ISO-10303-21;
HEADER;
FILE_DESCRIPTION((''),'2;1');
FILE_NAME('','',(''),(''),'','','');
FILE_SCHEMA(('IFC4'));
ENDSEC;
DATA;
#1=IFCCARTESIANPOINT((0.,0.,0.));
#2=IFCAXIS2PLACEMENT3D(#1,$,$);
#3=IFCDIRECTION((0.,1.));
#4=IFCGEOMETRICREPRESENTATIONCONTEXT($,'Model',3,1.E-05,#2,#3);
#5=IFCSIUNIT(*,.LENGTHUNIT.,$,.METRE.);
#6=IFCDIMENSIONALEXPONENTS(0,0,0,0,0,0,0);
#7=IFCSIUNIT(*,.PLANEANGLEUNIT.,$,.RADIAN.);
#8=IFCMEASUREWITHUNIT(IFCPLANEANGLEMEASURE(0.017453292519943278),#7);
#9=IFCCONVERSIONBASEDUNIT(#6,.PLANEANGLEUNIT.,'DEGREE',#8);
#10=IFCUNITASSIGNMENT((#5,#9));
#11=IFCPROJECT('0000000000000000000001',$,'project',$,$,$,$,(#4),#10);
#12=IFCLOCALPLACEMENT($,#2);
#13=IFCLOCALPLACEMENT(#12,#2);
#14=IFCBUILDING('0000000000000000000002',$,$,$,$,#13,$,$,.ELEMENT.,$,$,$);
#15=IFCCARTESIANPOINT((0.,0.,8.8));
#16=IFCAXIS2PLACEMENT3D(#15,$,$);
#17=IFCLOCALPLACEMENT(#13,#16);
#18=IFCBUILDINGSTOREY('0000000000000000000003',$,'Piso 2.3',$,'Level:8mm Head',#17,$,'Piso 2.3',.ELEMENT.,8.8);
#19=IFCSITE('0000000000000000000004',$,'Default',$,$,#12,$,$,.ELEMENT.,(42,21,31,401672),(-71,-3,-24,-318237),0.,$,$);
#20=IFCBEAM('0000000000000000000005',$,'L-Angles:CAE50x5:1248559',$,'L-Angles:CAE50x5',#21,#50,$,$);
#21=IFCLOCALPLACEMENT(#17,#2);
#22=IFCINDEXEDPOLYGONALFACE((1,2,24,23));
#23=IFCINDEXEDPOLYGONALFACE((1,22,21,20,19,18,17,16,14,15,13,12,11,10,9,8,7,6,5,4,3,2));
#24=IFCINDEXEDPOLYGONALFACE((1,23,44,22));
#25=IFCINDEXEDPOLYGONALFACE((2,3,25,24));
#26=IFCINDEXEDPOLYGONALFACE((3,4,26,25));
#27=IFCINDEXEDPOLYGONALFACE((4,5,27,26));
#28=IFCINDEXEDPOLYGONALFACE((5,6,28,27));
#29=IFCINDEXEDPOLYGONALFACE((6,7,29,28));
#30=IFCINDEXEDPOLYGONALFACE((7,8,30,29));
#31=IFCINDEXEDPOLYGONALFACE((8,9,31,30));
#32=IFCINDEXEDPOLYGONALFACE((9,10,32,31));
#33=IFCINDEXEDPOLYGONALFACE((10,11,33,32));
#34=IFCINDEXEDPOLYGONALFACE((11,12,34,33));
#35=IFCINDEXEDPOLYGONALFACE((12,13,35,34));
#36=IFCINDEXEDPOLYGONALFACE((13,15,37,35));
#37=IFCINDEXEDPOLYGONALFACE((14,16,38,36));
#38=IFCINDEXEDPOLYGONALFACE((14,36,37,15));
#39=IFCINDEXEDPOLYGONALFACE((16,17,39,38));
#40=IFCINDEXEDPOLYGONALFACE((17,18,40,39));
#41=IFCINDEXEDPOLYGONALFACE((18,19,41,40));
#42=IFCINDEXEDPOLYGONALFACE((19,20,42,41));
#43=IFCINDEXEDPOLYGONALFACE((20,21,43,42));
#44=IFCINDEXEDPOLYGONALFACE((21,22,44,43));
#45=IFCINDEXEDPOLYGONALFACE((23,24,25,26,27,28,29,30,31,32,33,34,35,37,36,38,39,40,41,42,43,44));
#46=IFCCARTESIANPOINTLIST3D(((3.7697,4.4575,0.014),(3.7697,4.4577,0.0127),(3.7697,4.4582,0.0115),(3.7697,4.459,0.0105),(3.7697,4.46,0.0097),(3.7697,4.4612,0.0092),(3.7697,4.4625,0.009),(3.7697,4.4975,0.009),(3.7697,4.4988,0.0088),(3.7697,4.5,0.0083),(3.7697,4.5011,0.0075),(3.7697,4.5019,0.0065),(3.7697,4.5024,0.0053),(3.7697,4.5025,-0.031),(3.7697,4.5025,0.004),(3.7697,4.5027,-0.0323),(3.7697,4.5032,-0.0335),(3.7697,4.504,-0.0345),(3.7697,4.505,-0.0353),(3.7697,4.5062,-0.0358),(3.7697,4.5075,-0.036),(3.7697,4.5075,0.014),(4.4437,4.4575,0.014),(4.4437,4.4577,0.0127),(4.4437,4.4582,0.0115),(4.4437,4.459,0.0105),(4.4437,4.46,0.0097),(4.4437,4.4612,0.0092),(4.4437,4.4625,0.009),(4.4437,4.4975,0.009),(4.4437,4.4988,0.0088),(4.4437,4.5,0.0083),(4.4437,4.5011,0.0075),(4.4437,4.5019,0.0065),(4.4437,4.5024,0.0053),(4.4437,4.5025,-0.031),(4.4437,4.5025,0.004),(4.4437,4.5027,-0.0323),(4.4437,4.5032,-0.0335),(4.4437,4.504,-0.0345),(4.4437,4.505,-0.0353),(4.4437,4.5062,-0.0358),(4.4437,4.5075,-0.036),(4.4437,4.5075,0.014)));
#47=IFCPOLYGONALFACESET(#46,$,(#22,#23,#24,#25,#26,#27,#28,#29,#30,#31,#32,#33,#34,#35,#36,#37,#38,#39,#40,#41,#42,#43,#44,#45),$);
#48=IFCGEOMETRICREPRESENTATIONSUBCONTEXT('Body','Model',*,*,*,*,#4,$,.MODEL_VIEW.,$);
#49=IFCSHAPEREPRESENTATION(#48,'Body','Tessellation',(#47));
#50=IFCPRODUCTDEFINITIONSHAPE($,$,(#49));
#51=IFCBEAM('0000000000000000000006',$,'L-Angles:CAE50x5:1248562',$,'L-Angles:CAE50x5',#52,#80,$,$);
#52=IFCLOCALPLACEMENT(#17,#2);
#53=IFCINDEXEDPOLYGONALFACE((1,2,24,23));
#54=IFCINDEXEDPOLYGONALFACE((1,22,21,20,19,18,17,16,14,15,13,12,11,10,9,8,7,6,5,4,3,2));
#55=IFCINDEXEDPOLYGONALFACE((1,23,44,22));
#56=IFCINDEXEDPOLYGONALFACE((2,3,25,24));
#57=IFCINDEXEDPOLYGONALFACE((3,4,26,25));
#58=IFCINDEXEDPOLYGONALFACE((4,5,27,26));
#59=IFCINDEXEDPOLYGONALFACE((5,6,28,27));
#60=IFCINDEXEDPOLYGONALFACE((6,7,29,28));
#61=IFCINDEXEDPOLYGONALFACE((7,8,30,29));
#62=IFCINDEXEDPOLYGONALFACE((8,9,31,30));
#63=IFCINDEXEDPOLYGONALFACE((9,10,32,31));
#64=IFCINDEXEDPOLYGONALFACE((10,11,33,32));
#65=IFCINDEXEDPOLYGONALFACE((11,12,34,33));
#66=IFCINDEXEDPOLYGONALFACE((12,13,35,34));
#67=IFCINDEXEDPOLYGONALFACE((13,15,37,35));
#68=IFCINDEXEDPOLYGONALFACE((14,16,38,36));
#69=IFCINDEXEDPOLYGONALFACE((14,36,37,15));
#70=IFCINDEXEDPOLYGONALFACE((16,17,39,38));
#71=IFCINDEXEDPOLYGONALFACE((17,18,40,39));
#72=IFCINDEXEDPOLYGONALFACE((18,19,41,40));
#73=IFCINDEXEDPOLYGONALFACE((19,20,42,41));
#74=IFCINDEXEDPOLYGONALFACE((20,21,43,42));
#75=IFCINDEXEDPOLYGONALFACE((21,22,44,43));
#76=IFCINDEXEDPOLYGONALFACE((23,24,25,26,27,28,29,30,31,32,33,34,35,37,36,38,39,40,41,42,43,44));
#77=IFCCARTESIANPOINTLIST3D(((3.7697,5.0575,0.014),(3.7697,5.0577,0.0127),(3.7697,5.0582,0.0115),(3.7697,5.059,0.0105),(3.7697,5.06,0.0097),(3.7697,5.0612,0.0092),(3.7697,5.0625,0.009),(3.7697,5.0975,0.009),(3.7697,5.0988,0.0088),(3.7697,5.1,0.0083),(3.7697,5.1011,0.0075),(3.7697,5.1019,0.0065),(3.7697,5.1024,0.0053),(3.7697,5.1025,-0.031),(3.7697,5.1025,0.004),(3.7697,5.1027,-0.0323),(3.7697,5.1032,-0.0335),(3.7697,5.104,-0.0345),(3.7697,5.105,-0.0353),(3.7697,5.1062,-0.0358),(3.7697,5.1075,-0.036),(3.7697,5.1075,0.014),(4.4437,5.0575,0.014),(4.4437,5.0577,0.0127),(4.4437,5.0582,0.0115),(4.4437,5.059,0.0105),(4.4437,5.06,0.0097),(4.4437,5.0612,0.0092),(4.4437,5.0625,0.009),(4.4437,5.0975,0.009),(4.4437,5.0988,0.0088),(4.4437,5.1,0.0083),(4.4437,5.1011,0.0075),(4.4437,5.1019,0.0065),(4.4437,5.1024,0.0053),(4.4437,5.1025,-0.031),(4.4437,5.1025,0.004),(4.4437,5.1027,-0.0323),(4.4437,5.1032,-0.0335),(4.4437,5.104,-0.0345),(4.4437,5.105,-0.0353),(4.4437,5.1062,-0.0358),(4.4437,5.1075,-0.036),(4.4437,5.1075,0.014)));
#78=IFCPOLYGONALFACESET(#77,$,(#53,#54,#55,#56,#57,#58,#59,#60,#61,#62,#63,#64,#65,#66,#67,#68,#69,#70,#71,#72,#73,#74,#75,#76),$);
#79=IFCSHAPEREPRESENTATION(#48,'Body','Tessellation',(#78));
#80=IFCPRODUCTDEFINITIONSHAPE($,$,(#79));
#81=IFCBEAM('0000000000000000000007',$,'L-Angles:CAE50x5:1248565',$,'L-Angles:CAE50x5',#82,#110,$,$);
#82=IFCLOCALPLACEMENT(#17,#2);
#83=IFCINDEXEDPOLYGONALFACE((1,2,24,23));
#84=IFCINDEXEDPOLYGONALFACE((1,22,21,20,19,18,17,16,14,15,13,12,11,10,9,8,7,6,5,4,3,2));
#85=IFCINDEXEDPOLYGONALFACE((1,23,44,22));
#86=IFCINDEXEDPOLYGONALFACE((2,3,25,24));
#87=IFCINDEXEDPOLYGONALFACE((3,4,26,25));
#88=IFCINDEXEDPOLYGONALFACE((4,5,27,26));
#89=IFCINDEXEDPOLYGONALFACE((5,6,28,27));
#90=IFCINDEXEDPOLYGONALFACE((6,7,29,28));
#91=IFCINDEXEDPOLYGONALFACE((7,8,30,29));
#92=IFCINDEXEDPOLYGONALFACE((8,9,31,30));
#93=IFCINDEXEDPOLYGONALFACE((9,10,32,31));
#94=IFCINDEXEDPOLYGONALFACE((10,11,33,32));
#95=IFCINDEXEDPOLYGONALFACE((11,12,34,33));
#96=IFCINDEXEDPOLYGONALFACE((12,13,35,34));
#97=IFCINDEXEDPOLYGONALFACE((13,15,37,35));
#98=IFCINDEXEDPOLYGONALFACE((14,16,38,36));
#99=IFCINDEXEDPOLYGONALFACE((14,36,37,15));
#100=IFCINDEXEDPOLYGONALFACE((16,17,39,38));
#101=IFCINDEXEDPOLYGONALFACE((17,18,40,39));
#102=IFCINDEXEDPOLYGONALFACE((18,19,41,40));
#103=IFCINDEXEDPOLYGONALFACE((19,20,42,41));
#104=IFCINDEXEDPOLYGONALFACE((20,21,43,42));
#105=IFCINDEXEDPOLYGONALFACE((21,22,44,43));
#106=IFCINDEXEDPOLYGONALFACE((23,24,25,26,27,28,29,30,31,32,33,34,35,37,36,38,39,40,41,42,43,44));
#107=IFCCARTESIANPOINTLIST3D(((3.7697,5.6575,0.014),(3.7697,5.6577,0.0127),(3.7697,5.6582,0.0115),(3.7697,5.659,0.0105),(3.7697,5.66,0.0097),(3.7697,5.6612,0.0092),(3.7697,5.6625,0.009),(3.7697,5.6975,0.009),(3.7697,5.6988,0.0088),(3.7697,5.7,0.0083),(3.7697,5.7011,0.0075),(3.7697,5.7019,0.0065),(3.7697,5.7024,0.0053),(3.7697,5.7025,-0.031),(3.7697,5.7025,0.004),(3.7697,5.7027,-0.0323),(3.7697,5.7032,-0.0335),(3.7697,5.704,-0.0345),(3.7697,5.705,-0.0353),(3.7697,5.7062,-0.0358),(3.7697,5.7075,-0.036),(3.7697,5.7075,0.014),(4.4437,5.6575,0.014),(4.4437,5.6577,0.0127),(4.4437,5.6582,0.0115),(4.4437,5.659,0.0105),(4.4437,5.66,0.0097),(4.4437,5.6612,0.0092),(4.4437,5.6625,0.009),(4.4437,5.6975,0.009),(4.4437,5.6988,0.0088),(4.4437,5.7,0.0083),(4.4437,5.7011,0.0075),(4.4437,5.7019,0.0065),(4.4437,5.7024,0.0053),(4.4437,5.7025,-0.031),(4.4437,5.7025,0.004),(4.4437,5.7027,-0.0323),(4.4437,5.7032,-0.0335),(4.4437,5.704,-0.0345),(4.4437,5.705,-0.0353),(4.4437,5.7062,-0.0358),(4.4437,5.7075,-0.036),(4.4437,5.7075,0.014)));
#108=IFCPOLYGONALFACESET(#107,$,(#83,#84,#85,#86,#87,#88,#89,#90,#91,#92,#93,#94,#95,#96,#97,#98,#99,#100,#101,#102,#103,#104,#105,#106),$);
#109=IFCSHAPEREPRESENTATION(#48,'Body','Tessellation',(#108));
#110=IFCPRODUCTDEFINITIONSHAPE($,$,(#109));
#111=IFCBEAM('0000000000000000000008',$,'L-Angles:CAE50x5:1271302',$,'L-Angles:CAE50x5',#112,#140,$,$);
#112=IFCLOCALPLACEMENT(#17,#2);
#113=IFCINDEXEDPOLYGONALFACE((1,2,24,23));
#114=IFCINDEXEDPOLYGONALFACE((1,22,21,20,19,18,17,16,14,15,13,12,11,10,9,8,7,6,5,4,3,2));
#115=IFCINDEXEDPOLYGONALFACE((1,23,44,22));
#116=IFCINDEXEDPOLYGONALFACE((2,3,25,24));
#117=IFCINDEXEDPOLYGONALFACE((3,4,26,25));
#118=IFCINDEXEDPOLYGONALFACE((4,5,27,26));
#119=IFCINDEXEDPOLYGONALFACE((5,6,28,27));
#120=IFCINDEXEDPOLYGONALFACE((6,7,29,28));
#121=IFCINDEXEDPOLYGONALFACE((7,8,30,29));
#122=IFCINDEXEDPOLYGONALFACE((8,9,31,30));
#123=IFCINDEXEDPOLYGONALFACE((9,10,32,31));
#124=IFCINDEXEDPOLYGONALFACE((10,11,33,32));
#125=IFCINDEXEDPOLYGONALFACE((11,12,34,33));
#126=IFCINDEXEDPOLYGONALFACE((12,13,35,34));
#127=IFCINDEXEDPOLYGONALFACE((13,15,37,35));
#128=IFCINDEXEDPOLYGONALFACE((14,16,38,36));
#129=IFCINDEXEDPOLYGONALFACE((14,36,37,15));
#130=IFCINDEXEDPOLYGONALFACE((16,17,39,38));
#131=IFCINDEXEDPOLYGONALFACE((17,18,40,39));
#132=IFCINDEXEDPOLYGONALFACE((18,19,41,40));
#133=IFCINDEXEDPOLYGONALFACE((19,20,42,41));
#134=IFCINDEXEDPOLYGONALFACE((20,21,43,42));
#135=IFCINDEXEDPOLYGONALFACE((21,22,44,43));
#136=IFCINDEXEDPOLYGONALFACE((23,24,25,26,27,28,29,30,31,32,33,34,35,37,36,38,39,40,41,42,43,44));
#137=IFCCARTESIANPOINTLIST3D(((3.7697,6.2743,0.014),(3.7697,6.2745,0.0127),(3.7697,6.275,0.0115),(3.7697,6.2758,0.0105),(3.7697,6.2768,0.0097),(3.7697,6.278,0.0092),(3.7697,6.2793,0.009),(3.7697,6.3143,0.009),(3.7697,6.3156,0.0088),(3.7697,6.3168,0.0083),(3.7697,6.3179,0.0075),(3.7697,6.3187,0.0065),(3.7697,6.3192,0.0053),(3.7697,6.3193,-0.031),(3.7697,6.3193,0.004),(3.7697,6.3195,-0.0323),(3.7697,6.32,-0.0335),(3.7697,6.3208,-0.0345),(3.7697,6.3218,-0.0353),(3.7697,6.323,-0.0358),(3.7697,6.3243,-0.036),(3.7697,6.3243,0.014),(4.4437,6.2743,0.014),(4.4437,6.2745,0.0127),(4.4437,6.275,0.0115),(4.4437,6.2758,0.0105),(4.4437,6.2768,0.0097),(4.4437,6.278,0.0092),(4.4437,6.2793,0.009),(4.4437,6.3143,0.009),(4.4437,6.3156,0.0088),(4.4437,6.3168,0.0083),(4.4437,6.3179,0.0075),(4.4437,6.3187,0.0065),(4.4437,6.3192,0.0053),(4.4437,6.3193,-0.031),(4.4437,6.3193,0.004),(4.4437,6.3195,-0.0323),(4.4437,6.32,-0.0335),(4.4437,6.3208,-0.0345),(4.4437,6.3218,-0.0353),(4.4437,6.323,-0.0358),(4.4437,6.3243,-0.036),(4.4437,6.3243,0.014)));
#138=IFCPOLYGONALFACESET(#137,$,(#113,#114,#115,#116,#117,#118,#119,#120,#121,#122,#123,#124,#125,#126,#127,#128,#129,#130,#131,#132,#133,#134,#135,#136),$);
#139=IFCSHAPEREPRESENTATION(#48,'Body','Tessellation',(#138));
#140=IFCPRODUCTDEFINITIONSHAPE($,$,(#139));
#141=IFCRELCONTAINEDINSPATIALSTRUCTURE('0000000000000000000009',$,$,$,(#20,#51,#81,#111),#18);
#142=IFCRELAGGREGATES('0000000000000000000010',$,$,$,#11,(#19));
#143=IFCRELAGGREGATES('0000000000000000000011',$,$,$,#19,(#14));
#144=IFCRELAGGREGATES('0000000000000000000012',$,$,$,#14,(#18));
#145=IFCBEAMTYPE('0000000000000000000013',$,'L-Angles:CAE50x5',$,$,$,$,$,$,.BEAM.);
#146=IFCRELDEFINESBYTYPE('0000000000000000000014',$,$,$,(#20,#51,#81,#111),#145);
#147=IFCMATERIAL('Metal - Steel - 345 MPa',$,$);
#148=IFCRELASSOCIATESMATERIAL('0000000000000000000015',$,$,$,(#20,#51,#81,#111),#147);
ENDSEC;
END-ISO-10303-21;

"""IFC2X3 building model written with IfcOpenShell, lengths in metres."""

from ifc_helpers import new_model, entity, si_unit, converted_unit, direction, frame, frame_2d, origin, place, context, subcontext, project, spatial, polyline, circle_curve, parameter, trimmed, segment, composite_curve, outline, extrude, material, type_object, element, save


model = new_model("IFC2X3")

# Units and contexts
model_context = context("Model", 3, precision=1e-05, world=origin(), true_north=direction((0.0, 1.0)))
body_context = subcontext(model_context, "Body", "Model", "MODEL_VIEW")
ifc_project = project(units=[si_unit("LENGTHUNIT", "METRE"), converted_unit("PLANEANGLEUNIT", "DEGREE", entity("IfcPlaneAngleMeasure", 0.017453292519943278), si_unit("PLANEANGLEUNIT", "RADIAN"), dimensions=[0, 0, 0, 0, 0, 0, 0])], contexts=[model_context])

# Site, building, storey
site_placement = place(None, origin())
site = spatial("IfcSite", under=ifc_project, at=site_placement, Name="Default", CompositionType="ELEMENT", RefLatitude=(42, 21, 31, 401672), RefLongitude=(-71, -3, -24, -318237), RefElevation=0.0)
building_placement = place(site_placement, origin())
building = spatial("IfcBuilding", under=site, at=building_placement, CompositionType="ELEMENT")
storey_placement = place(building_placement, frame((0.0, 0.0, 8.8)))
storey = spatial("IfcBuildingStorey", under=building, at=storey_placement, Name="Piso 2.3", ObjectType="Level:8mm Head", LongName="Piso 2.3", CompositionType="ELEMENT", Elevation=8.8)

# Beams
ifc_material_1 = material(Name="Metal - Steel - 345 MPa")
beam_type_1 = type_object("IfcBeamType", Name="L-Angles:CAE50x5", PredefinedType="BEAM")
beam_1_placement = place(storey_placement, frame((3.7067, 4.4935, 0.0)))
element("IfcBeam", 1, at=beam_1_placement, inside=storey, type_object=beam_type_1, material=ifc_material_1, Name="L-Angles:CAE50x5:1248559", ObjectType="L-Angles:CAE50x5", context=body_context, shape_type="SweptSolid", body=[
    extrude(outline(composite_curve([segment(polyline([(-0.0336, -0.0164), (0.0164, -0.0164)]), True, "CONTINUOUS"), segment(polyline([(0.0164, -0.0164), (0.0164, 0.0336)]), True, "CONTINUOUS"), segment(trimmed(circle_curve(frame_2d((0.0164, 0.0286), x_axis=(0.0, 1.0)), 0.005), [parameter(0.0)], [parameter(90.0)], True, "PARAMETER"), True, "CONTINUOUS"), segment(polyline([(0.0114, 0.0286), (0.0114, -0.0064)]), True, "CONTINUOUS"), segment(trimmed(circle_curve(frame_2d((0.0064, -0.0064), x_axis=(1.0, 0.0)), 0.005), [parameter(270.0)], [parameter(0.0)], True, "PARAMETER"), False, "CONTINUOUS"), segment(polyline([(0.0064, -0.0114), (-0.0286, -0.0114)]), True, "CONTINUOUS"), segment(trimmed(circle_curve(frame_2d((-0.0286, -0.0164), x_axis=(0.0, 1.0)), 0.005), [parameter(0.0)], [parameter(90.0)], True, "PARAMETER"), True, "CONTINUOUS")], self_intersect=False)), frame((0.063, -0.0024, -0.0024), z_axis=(1.0, 0.0, 0.0), x_axis=(0.0, 0.0, 1.0)), (0.0, 0.0, 1.0), 0.674),
])
beam_2_placement = place(storey_placement, frame((3.7067, 5.0935, 0.0)))
element("IfcBeam", 2, at=beam_2_placement, inside=storey, type_object=beam_type_1, material=ifc_material_1, Name="L-Angles:CAE50x5:1248562", ObjectType="L-Angles:CAE50x5", context=body_context, shape_type="SweptSolid", body=[
    extrude(outline(composite_curve([segment(polyline([(-0.0336, -0.0164), (0.0164, -0.0164)]), True, "CONTINUOUS"), segment(polyline([(0.0164, -0.0164), (0.0164, 0.0336)]), True, "CONTINUOUS"), segment(trimmed(circle_curve(frame_2d((0.0164, 0.0286), x_axis=(0.0, 1.0)), 0.005), [parameter(0.0)], [parameter(90.0)], True, "PARAMETER"), True, "CONTINUOUS"), segment(polyline([(0.0114, 0.0286), (0.0114, -0.0064)]), True, "CONTINUOUS"), segment(trimmed(circle_curve(frame_2d((0.0064, -0.0064), x_axis=(1.0, 0.0)), 0.005), [parameter(270.0)], [parameter(0.0)], True, "PARAMETER"), False, "CONTINUOUS"), segment(polyline([(0.0064, -0.0114), (-0.0286, -0.0114)]), True, "CONTINUOUS"), segment(trimmed(circle_curve(frame_2d((-0.0286, -0.0164), x_axis=(0.0, 1.0)), 0.005), [parameter(0.0)], [parameter(90.0)], True, "PARAMETER"), True, "CONTINUOUS")], self_intersect=False)), frame((0.063, -0.0024, -0.0024), z_axis=(1.0, 0.0, 0.0), x_axis=(0.0, 0.0, 1.0)), (0.0, 0.0, 1.0), 0.674),
])
beam_3_placement = place(storey_placement, frame((3.7067, 5.6935, 0.0)))
element("IfcBeam", 3, at=beam_3_placement, inside=storey, type_object=beam_type_1, material=ifc_material_1, Name="L-Angles:CAE50x5:1248565", ObjectType="L-Angles:CAE50x5", context=body_context, shape_type="SweptSolid", body=[
    extrude(outline(composite_curve([segment(polyline([(-0.0336, -0.0164), (0.0164, -0.0164)]), True, "CONTINUOUS"), segment(polyline([(0.0164, -0.0164), (0.0164, 0.0336)]), True, "CONTINUOUS"), segment(trimmed(circle_curve(frame_2d((0.0164, 0.0286), x_axis=(0.0, 1.0)), 0.005), [parameter(0.0)], [parameter(90.0)], True, "PARAMETER"), True, "CONTINUOUS"), segment(polyline([(0.0114, 0.0286), (0.0114, -0.0064)]), True, "CONTINUOUS"), segment(trimmed(circle_curve(frame_2d((0.0064, -0.0064), x_axis=(1.0, 0.0)), 0.005), [parameter(270.0)], [parameter(0.0)], True, "PARAMETER"), False, "CONTINUOUS"), segment(polyline([(0.0064, -0.0114), (-0.0286, -0.0114)]), True, "CONTINUOUS"), segment(trimmed(circle_curve(frame_2d((-0.0286, -0.0164), x_axis=(0.0, 1.0)), 0.005), [parameter(0.0)], [parameter(90.0)], True, "PARAMETER"), True, "CONTINUOUS")], self_intersect=False)), frame((0.063, -0.0024, -0.0024), z_axis=(1.0, 0.0, 0.0), x_axis=(0.0, 0.0, 1.0)), (0.0, 0.0, 1.0), 0.674),
])
beam_4_placement = place(storey_placement, frame((3.7067, 6.3103, 0.0)))
element("IfcBeam", 4, at=beam_4_placement, inside=storey, type_object=beam_type_1, material=ifc_material_1, Name="L-Angles:CAE50x5:1271302", ObjectType="L-Angles:CAE50x5", context=body_context, shape_type="SweptSolid", body=[
    extrude(outline(composite_curve([segment(polyline([(-0.0336, -0.0164), (0.0164, -0.0164)]), True, "CONTINUOUS"), segment(polyline([(0.0164, -0.0164), (0.0164, 0.0336)]), True, "CONTINUOUS"), segment(trimmed(circle_curve(frame_2d((0.0164, 0.0286), x_axis=(0.0, 1.0)), 0.005), [parameter(0.0)], [parameter(90.0)], True, "PARAMETER"), True, "CONTINUOUS"), segment(polyline([(0.0114, 0.0286), (0.0114, -0.0064)]), True, "CONTINUOUS"), segment(trimmed(circle_curve(frame_2d((0.0064, -0.0064), x_axis=(1.0, 0.0)), 0.005), [parameter(270.0)], [parameter(0.0)], True, "PARAMETER"), False, "CONTINUOUS"), segment(polyline([(0.0064, -0.0114), (-0.0286, -0.0114)]), True, "CONTINUOUS"), segment(trimmed(circle_curve(frame_2d((-0.0286, -0.0164), x_axis=(0.0, 1.0)), 0.005), [parameter(0.0)], [parameter(90.0)], True, "PARAMETER"), True, "CONTINUOUS")], self_intersect=False)), frame((0.063, -0.0024, -0.0024), z_axis=(1.0, 0.0, 0.0), x_axis=(0.0, 0.0, 1.0)), (0.0, 0.0, 1.0), 0.674),
])

save(model, "model.ifc")
